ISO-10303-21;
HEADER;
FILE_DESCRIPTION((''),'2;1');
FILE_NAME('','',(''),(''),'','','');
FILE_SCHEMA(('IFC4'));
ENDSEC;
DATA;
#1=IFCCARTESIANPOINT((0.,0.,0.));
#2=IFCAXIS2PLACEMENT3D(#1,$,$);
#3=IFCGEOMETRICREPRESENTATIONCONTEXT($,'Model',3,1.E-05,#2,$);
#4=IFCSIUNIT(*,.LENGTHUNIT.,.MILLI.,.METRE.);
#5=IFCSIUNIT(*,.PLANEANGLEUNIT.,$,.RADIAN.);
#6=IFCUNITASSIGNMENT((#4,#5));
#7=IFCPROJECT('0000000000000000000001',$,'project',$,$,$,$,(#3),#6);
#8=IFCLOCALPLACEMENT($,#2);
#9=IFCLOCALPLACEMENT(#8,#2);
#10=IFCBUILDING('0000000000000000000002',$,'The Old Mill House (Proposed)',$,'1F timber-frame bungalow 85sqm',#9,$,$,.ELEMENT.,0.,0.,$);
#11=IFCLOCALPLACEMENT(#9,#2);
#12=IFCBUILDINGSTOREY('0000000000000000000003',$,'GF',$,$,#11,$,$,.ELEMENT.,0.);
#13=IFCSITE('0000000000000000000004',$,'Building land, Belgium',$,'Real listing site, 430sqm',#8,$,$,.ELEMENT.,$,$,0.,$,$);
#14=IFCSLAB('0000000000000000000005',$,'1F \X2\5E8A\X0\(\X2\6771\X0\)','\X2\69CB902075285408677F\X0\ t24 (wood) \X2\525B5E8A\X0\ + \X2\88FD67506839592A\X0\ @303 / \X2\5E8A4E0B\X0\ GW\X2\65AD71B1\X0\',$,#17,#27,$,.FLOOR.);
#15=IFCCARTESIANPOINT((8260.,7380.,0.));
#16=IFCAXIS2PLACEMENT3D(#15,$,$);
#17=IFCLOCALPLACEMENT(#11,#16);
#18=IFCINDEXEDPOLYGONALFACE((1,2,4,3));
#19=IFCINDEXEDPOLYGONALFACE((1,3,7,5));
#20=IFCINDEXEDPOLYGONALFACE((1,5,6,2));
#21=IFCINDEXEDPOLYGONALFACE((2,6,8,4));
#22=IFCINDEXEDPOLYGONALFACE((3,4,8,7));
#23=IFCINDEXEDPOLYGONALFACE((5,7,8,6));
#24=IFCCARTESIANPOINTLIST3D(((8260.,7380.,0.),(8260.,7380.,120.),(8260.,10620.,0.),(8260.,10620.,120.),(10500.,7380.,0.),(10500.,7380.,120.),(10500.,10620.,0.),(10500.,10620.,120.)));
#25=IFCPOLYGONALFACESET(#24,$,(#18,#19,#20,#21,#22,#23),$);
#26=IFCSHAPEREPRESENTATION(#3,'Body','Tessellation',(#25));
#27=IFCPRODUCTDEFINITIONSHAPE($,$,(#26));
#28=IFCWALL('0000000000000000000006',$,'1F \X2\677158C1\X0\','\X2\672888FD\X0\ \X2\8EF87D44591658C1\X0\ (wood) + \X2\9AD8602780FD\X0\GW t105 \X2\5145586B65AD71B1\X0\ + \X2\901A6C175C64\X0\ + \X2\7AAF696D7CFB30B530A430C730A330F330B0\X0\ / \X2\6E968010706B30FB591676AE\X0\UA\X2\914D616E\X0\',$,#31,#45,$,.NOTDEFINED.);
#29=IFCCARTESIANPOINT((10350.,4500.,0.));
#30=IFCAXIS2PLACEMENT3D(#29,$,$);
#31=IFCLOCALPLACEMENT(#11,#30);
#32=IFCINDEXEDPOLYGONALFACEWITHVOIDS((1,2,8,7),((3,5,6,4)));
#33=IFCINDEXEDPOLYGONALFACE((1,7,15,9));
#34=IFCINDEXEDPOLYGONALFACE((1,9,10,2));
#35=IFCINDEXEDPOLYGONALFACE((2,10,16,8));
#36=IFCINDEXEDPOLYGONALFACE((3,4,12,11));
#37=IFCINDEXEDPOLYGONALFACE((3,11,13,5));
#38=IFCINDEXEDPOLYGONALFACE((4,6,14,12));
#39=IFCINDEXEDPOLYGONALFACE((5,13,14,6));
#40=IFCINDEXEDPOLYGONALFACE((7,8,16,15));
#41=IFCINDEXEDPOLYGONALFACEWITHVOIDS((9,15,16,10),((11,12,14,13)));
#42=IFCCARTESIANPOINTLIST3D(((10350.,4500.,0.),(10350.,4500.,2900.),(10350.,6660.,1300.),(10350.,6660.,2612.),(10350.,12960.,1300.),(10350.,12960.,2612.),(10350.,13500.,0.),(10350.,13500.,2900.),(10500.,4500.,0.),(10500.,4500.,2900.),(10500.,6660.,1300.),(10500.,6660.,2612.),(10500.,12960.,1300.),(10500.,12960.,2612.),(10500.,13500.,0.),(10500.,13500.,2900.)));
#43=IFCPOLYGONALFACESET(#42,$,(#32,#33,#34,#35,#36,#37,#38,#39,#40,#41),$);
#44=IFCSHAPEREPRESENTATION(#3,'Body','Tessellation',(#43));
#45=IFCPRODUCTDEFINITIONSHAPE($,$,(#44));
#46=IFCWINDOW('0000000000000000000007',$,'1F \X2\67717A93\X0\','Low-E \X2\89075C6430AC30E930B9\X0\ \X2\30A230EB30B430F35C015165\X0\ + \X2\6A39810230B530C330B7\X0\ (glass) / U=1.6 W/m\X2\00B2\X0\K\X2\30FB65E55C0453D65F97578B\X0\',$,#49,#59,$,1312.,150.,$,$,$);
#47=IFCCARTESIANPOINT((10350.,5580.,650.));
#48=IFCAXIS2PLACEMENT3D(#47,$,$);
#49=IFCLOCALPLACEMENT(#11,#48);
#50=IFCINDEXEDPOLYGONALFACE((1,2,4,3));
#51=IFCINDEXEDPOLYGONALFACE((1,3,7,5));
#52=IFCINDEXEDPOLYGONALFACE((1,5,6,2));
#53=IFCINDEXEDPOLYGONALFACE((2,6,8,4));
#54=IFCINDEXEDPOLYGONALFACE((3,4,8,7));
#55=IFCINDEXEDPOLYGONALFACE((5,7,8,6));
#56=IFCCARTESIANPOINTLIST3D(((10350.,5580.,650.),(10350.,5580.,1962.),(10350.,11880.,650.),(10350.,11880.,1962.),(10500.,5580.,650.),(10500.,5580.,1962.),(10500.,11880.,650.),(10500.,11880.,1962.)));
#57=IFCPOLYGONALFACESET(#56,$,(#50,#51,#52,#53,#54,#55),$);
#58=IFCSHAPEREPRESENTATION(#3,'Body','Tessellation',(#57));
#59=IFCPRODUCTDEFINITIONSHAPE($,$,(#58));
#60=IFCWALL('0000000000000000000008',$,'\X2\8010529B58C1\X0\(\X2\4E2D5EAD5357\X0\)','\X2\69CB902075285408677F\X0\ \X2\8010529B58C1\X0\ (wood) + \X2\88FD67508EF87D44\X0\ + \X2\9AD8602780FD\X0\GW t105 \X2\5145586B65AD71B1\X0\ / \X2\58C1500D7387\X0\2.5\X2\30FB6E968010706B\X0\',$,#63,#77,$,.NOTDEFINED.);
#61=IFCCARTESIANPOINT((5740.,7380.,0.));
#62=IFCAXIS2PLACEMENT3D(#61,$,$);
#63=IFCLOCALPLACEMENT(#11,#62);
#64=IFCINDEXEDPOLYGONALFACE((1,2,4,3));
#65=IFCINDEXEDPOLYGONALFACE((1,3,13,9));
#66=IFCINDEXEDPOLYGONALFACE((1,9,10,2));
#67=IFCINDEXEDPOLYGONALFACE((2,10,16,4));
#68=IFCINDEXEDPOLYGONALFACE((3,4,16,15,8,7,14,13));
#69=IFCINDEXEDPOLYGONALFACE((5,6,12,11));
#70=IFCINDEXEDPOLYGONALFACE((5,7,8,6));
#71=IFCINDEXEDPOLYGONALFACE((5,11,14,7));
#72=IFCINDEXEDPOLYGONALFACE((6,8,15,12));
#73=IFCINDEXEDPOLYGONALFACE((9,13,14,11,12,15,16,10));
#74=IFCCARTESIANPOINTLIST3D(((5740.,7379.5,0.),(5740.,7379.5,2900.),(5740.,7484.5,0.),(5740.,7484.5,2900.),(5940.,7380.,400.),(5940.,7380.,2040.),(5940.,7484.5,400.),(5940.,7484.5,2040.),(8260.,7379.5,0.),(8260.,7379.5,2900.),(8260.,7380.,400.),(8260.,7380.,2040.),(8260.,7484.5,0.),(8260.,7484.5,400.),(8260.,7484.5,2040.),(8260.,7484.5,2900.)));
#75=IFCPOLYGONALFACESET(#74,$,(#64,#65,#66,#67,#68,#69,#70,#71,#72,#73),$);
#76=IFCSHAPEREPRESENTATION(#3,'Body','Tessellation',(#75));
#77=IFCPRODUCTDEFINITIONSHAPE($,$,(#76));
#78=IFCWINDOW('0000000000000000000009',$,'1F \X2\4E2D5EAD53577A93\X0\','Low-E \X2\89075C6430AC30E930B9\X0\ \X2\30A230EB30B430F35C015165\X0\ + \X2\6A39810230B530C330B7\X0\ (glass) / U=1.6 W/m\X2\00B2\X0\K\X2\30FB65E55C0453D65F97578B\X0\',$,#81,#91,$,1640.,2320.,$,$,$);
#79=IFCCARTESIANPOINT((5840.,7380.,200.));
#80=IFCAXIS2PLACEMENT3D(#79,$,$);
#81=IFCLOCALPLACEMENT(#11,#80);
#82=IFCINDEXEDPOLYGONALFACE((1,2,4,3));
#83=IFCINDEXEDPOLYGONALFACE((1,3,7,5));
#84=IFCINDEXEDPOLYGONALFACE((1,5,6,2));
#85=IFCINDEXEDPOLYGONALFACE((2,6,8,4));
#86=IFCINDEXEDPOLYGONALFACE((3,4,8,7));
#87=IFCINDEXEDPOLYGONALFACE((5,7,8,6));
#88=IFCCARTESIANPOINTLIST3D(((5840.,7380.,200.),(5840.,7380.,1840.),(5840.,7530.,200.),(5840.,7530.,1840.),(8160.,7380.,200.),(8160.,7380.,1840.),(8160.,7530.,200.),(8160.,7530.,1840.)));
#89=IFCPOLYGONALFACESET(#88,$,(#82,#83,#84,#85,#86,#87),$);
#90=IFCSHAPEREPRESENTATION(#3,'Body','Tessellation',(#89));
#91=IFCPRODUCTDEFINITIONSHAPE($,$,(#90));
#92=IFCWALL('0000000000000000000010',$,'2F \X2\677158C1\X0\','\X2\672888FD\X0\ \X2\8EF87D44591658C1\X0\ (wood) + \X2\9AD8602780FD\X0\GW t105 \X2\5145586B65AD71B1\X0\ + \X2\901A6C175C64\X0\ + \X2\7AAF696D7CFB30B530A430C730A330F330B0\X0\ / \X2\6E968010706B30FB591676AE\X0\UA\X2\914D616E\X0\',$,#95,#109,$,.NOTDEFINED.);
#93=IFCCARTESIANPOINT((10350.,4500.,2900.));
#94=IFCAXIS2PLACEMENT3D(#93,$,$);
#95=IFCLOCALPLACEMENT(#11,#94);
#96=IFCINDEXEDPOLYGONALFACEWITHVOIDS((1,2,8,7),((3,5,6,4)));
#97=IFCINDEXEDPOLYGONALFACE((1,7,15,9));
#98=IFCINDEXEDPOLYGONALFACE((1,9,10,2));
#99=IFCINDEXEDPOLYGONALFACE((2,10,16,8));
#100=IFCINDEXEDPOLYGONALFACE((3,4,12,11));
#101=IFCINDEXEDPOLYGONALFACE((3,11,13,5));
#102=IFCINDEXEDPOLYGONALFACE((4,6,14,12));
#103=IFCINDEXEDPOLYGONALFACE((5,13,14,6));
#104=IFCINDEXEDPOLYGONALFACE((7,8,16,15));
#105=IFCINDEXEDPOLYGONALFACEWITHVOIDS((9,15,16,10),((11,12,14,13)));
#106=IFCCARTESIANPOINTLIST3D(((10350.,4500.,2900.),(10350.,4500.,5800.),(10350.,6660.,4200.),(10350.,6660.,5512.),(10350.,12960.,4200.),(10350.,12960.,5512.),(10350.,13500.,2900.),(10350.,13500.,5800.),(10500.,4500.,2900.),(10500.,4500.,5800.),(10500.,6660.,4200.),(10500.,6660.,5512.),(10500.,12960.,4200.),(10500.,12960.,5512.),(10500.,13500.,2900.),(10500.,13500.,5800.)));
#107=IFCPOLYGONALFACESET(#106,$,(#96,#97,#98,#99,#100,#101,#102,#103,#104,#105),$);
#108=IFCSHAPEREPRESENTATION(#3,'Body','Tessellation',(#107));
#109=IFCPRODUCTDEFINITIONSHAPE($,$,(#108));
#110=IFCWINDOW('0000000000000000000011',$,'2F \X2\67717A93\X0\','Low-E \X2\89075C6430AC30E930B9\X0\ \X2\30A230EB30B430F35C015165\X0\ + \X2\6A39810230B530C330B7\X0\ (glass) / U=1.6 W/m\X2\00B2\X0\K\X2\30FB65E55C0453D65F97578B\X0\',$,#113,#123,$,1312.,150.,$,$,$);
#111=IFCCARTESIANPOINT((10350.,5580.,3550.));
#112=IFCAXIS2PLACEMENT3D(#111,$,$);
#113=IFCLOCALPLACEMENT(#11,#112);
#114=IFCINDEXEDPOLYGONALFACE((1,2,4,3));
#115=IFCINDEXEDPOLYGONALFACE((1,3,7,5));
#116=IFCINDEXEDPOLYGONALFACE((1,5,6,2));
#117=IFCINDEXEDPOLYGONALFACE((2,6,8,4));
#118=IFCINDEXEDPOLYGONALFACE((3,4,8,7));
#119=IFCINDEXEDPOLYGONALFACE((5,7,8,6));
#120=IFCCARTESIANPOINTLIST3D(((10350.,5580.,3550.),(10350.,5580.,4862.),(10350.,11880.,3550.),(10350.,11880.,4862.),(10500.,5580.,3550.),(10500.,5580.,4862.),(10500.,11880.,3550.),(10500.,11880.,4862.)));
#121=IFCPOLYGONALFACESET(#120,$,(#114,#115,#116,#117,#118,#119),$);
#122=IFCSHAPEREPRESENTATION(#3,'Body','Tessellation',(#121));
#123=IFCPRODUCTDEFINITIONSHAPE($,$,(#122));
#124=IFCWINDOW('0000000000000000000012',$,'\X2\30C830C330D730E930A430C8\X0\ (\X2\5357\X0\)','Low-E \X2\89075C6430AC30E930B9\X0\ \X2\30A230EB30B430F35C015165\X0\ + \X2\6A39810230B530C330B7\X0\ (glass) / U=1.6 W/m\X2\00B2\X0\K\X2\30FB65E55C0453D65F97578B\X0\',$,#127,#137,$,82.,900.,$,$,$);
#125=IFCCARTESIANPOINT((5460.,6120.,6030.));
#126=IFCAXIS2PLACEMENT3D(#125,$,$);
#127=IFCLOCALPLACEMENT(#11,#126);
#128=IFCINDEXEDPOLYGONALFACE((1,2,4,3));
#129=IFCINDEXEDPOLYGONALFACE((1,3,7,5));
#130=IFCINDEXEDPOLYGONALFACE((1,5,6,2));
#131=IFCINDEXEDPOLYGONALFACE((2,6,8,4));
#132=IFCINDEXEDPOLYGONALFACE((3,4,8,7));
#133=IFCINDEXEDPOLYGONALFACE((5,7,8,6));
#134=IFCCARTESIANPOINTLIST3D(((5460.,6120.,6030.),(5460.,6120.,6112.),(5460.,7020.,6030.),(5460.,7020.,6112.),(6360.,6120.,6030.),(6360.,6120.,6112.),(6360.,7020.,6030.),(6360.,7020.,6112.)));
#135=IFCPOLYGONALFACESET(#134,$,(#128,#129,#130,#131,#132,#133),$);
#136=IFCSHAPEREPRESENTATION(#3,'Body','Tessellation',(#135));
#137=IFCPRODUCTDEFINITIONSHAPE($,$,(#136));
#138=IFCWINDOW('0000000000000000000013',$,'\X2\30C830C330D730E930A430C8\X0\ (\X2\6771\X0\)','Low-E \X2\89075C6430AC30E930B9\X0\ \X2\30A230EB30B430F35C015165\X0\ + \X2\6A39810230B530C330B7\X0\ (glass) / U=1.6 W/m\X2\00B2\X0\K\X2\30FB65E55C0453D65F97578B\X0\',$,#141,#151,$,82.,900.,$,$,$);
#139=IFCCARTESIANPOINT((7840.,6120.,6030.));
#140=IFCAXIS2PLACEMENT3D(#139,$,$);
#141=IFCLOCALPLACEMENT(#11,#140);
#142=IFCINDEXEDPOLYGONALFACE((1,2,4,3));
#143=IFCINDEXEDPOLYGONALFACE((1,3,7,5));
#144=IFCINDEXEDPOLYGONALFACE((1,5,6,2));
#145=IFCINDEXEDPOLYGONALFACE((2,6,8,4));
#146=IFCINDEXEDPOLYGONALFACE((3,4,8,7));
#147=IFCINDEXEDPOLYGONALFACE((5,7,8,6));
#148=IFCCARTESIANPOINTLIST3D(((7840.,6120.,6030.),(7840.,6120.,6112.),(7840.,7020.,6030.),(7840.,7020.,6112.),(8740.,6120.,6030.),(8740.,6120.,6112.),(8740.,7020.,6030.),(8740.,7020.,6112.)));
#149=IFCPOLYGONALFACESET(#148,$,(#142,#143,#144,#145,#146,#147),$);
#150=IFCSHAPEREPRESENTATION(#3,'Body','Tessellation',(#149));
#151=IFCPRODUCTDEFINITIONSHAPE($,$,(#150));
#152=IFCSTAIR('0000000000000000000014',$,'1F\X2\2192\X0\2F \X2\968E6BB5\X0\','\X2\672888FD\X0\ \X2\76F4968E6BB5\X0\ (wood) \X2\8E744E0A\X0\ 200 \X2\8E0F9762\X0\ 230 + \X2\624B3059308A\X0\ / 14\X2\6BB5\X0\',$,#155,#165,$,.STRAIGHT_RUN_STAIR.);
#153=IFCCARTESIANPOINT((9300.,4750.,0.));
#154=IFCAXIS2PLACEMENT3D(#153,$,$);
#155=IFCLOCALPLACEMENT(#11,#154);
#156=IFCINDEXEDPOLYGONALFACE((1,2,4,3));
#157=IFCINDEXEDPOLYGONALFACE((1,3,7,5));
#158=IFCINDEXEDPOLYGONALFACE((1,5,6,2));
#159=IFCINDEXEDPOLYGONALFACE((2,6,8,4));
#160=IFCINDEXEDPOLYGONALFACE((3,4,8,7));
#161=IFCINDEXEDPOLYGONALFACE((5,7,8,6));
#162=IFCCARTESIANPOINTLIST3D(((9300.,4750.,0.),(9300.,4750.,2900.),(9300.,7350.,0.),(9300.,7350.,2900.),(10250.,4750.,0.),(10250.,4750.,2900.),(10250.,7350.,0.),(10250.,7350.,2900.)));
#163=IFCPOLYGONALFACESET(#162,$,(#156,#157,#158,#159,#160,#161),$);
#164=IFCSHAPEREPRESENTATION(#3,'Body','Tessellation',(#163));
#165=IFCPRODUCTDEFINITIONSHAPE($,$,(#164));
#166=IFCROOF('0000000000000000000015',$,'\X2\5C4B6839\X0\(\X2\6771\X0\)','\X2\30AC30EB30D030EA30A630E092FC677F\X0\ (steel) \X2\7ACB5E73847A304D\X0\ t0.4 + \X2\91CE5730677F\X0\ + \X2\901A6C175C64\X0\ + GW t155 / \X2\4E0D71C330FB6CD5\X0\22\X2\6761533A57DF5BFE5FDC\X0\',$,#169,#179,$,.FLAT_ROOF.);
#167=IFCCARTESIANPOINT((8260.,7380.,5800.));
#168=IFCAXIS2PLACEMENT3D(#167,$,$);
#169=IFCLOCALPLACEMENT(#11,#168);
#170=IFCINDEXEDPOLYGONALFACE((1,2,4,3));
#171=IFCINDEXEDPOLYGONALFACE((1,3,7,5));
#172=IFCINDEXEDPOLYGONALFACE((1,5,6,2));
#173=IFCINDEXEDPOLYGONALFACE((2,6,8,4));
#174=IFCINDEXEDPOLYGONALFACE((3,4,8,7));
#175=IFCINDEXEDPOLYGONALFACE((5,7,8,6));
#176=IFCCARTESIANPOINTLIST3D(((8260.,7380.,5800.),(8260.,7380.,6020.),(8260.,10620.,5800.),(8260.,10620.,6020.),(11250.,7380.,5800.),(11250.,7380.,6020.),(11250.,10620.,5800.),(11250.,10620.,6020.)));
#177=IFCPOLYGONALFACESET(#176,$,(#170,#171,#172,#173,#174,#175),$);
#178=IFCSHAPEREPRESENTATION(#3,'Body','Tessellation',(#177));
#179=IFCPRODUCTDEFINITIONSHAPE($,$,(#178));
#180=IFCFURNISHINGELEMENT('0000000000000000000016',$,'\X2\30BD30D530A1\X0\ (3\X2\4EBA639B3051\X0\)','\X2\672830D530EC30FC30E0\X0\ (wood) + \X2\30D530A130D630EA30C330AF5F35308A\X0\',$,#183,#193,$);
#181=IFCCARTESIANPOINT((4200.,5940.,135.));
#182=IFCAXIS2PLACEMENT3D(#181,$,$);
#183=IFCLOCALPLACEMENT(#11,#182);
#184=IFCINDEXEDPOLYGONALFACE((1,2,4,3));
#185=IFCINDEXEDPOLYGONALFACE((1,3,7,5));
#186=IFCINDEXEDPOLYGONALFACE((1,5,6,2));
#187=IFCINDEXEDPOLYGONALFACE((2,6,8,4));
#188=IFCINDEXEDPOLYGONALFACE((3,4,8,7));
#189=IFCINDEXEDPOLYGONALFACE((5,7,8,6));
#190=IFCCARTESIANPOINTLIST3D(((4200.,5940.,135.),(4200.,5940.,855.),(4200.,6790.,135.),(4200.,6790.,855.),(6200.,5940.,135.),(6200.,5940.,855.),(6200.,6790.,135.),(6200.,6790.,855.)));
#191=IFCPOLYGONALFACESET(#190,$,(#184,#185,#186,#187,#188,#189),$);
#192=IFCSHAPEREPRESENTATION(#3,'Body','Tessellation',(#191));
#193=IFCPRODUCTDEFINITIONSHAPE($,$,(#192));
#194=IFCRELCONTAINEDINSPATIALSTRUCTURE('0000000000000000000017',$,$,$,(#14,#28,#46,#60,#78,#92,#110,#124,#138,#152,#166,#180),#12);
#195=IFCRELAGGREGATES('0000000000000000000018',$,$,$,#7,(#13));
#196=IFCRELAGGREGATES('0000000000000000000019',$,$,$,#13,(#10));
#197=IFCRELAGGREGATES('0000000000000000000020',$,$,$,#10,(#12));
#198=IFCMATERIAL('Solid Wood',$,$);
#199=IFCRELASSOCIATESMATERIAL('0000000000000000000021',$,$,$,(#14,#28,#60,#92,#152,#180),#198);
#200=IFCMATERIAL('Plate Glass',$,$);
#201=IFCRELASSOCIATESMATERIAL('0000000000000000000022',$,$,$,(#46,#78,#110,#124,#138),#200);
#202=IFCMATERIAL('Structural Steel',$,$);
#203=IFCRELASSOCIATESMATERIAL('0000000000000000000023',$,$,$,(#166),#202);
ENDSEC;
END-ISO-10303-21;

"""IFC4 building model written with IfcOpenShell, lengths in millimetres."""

from ifc_helpers import new_model, si_unit, frame, frame_2d, origin, place, context, project, spatial, rectangle, extrude, material, element, fill, save


model = new_model("IFC4")

# Units and contexts
model_context = context("Model", 3, precision=1e-05, world=origin())
ifc_project = project(units=[si_unit("LENGTHUNIT", "METRE", prefix="MILLI"), si_unit("PLANEANGLEUNIT", "RADIAN")], contexts=[model_context])

# Site, building, storey
site_placement = place(None, origin())
site = spatial("IfcSite", under=ifc_project, at=site_placement, Name="Building land, Belgium", ObjectType="Real listing site, 430sqm", CompositionType="ELEMENT", RefElevation=0.0)
building_placement = place(site_placement, origin())
building = spatial("IfcBuilding", under=site, at=building_placement, Name="The Old Mill House (Proposed)", ObjectType="1F timber-frame bungalow 85sqm", CompositionType="ELEMENT", ElevationOfRefHeight=0.0, ElevationOfTerrain=0.0)
storey_placement = place(building_placement, origin())
storey = spatial("IfcBuildingStorey", under=building, at=storey_placement, Name="GF", CompositionType="ELEMENT", Elevation=0.0)

# Slab
ifc_material_1 = material(Name="Solid Wood")
slab_placement = place(storey_placement, frame((8260.0, 7380.0, 0.0)))
element("IfcSlab", 1, at=slab_placement, inside=storey, material=ifc_material_1, Name="1F 床(東)", Description="構造用合板 t24 (wood) 剛床 + 製材根太 @303 / 床下 GW断熱", PredefinedType="FLOOR", context=model_context, shape_type="SweptSolid", body=[
    extrude(rectangle(XDim=2240.0, YDim=3240.0, at=frame_2d((1120.0, 1620.0))), frame((8260.0, 7380.0, 0.0)), (0.0, 0.0, 1.0), 120.0),
])

# Walls, openings, windows
wall_1_placement = place(storey_placement, frame((10350.0, 4500.0, 0.0)))
wall_1 = element("IfcWall", 2, at=wall_1_placement, inside=storey, material=ifc_material_1, Name="1F 東壁", Description="木製 軸組外壁 (wood) + 高性能GW t105 充填断熱 + 通気層 + 窯業系サイディング / 準耐火・外皮UA配慮", PredefinedType="NOTDEFINED", context=model_context, shape_type="SweptSolid", body=[
    extrude(rectangle(XDim=150.0, YDim=9000.0, at=frame_2d((75.0, 4500.0))), frame((10350.0, 4500.0, 0.0)), (0.0, 0.0, 1.0), 2900.0),
])
opening_1_placement = place(storey_placement, frame((10350.0, 5580.0, 650.0)))
opening_1 = element("IfcOpeningElement", 3, at=opening_1_placement, cuts=wall_1, PredefinedType="NOTDEFINED", context=model_context, shape_type="SweptSolid", body=[
    extrude(rectangle(XDim=150.0, YDim=6300.0, at=frame_2d((75.0, 3150.0))), frame((10350.0, 5580.0, 650.0)), (0.0, 0.0, 1.0), 1312.0),
])
ifc_material_2 = material(Name="Plate Glass")
window_1_placement = place(storey_placement, frame((10350.0, 5580.0, 650.0)))
window_1 = element("IfcWindow", 4, at=window_1_placement, inside=storey, material=ifc_material_2, Name="1F 東窓", Description="Low-E 複層ガラス アルゴン封入 + 樹脂サッシ (glass) / U=1.6 W/m²K・日射取得型", OverallHeight=1312.0, OverallWidth=150.0, context=model_context, shape_type="SweptSolid", body=[
    extrude(rectangle(XDim=150.0, YDim=6300.0, at=frame_2d((75.0, 3150.0))), frame((10350.0, 5580.0, 650.0)), (0.0, 0.0, 1.0), 1312.0),
])
fill(opening_1, window_1)
wall_2_placement = place(storey_placement, frame((5740.0, 7380.0, 0.0)))
wall_2 = element("IfcWall", 5, at=wall_2_placement, inside=storey, material=ifc_material_1, Name="耐力壁(中庭南)", Description="構造用合板 耐力壁 (wood) + 製材軸組 + 高性能GW t105 充填断熱 / 壁倍率2.5・準耐火", PredefinedType="NOTDEFINED", context=model_context, shape_type="SweptSolid", body=[
    extrude(rectangle(XDim=2520.0, YDim=105.0, at=frame_2d((1260.0, 52.0))), frame((5740.0, 7380.0, 0.0)), (0.0, 0.0, 1.0), 2900.0),
])
opening_2_placement = place(storey_placement, frame((5840.0, 7380.0, 200.0)))
opening_2 = element("IfcOpeningElement", 6, at=opening_2_placement, cuts=wall_2, PredefinedType="NOTDEFINED", context=model_context, shape_type="SweptSolid", body=[
    extrude(rectangle(XDim=2320.0, YDim=150.0, at=frame_2d((1160.0, 75.0))), frame((5840.0, 7380.0, 200.0)), (0.0, 0.0, 1.0), 1640.0),
])
window_2_placement = place(storey_placement, frame((5840.0, 7380.0, 200.0)))
window_2 = element("IfcWindow", 7, at=window_2_placement, inside=storey, material=ifc_material_2, Name="1F 中庭南窓", Description="Low-E 複層ガラス アルゴン封入 + 樹脂サッシ (glass) / U=1.6 W/m²K・日射取得型", OverallHeight=1640.0, OverallWidth=2320.0, context=model_context, shape_type="SweptSolid", body=[
    extrude(rectangle(XDim=2320.0, YDim=150.0, at=frame_2d((1160.0, 75.0))), frame((5840.0, 7380.0, 200.0)), (0.0, 0.0, 1.0), 1640.0),
])
fill(opening_2, window_2)

# Wall, opening, window
wall_3_placement = place(storey_placement, frame((10350.0, 4500.0, 2900.0)))
wall_3 = element("IfcWall", 8, at=wall_3_placement, inside=storey, material=ifc_material_1, Name="2F 東壁", Description="木製 軸組外壁 (wood) + 高性能GW t105 充填断熱 + 通気層 + 窯業系サイディング / 準耐火・外皮UA配慮", PredefinedType="NOTDEFINED", context=model_context, shape_type="SweptSolid", body=[
    extrude(rectangle(XDim=150.0, YDim=9000.0, at=frame_2d((75.0, 4500.0))), frame((10350.0, 4500.0, 2900.0)), (0.0, 0.0, 1.0), 2900.0),
])
opening_3_placement = place(storey_placement, frame((10350.0, 5580.0, 3550.0)))
opening_3 = element("IfcOpeningElement", 9, at=opening_3_placement, cuts=wall_3, PredefinedType="NOTDEFINED", context=model_context, shape_type="SweptSolid", body=[
    extrude(rectangle(XDim=150.0, YDim=6300.0, at=frame_2d((75.0, 3150.0))), frame((10350.0, 5580.0, 3550.0)), (0.0, 0.0, 1.0), 1312.0),
])
window_3_placement = place(storey_placement, frame((10350.0, 5580.0, 3550.0)))
window_3 = element("IfcWindow", 10, at=window_3_placement, inside=storey, material=ifc_material_2, Name="2F 東窓", Description="Low-E 複層ガラス アルゴン封入 + 樹脂サッシ (glass) / U=1.6 W/m²K・日射取得型", OverallHeight=1312.0, OverallWidth=150.0, context=model_context, shape_type="SweptSolid", body=[
    extrude(rectangle(XDim=150.0, YDim=6300.0, at=frame_2d((75.0, 3150.0))), frame((10350.0, 5580.0, 3550.0)), (0.0, 0.0, 1.0), 1312.0),
])
fill(opening_3, window_3)

# Windows
window_4_placement = place(storey_placement, frame((5460.0, 6120.0, 6030.0)))
element("IfcWindow", 11, at=window_4_placement, inside=storey, material=ifc_material_2, Name="トップライト (南)", Description="Low-E 複層ガラス アルゴン封入 + 樹脂サッシ (glass) / U=1.6 W/m²K・日射取得型", OverallHeight=82.0, OverallWidth=900.0, context=model_context, shape_type="SweptSolid", body=[
    extrude(rectangle(XDim=900.0, YDim=900.0, at=frame_2d((450.0, 450.0))), frame((5460.0, 6120.0, 6030.0)), (0.0, 0.0, 1.0), 82.0),
])
window_5_placement = place(storey_placement, frame((7840.0, 6120.0, 6030.0)))
element("IfcWindow", 12, at=window_5_placement, inside=storey, material=ifc_material_2, Name="トップライト (東)", Description="Low-E 複層ガラス アルゴン封入 + 樹脂サッシ (glass) / U=1.6 W/m²K・日射取得型", OverallHeight=82.0, OverallWidth=900.0, context=model_context, shape_type="SweptSolid", body=[
    extrude(rectangle(XDim=900.0, YDim=900.0, at=frame_2d((450.0, 450.0))), frame((7840.0, 6120.0, 6030.0)), (0.0, 0.0, 1.0), 82.0),
])

# Stair
stair_placement = place(storey_placement, frame((9300.0, 4750.0, 0.0)))
element("IfcStair", 13, at=stair_placement, inside=storey, material=ifc_material_1, Name="1F→2F 階段", Description="木製 直階段 (wood) 蹴上 200 踏面 230 + 手すり / 14段", PredefinedType="STRAIGHT_RUN_STAIR", context=model_context, shape_type="SweptSolid", body=[
    extrude(rectangle(XDim=950.0, YDim=2600.0, at=frame_2d((475.0, 1300.0))), frame((9300.0, 4750.0, 0.0)), (0.0, 0.0, 1.0), 2900.0),
])

# Roof
ifc_material_3 = material(Name="Structural Steel")
roof_placement = place(storey_placement, frame((8260.0, 7380.0, 5800.0)))
element("IfcRoof", 14, at=roof_placement, inside=storey, material=ifc_material_3, Name="屋根(東)", Description="ガルバリウム鋼板 (steel) 立平葺き t0.4 + 野地板 + 通気層 + GW t155 / 不燃・法22条区域対応", PredefinedType="FLAT_ROOF", context=model_context, shape_type="SweptSolid", body=[
    extrude(rectangle(XDim=2990.0, YDim=3240.0, at=frame_2d((1495.0, 1620.0))), frame((8260.0, 7380.0, 5800.0)), (0.0, 0.0, 1.0), 220.0),
])

# Furnishing element
furnishing_1_placement = place(storey_placement, frame((4200.0, 5940.0, 135.0)))
element("IfcFurnishingElement", 15, at=furnishing_1_placement, inside=storey, material=ifc_material_1, Name="ソファ (3人掛け)", Description="木フレーム (wood) + ファブリック張り", context=model_context, shape_type="SweptSolid", body=[
    extrude(rectangle(XDim=2000.0, YDim=850.0, at=frame_2d((1000.0, 425.0))), frame((4200.0, 5940.0, 135.0)), (0.0, 0.0, 1.0), 720.0),
])

save(model, "model.ifc")
